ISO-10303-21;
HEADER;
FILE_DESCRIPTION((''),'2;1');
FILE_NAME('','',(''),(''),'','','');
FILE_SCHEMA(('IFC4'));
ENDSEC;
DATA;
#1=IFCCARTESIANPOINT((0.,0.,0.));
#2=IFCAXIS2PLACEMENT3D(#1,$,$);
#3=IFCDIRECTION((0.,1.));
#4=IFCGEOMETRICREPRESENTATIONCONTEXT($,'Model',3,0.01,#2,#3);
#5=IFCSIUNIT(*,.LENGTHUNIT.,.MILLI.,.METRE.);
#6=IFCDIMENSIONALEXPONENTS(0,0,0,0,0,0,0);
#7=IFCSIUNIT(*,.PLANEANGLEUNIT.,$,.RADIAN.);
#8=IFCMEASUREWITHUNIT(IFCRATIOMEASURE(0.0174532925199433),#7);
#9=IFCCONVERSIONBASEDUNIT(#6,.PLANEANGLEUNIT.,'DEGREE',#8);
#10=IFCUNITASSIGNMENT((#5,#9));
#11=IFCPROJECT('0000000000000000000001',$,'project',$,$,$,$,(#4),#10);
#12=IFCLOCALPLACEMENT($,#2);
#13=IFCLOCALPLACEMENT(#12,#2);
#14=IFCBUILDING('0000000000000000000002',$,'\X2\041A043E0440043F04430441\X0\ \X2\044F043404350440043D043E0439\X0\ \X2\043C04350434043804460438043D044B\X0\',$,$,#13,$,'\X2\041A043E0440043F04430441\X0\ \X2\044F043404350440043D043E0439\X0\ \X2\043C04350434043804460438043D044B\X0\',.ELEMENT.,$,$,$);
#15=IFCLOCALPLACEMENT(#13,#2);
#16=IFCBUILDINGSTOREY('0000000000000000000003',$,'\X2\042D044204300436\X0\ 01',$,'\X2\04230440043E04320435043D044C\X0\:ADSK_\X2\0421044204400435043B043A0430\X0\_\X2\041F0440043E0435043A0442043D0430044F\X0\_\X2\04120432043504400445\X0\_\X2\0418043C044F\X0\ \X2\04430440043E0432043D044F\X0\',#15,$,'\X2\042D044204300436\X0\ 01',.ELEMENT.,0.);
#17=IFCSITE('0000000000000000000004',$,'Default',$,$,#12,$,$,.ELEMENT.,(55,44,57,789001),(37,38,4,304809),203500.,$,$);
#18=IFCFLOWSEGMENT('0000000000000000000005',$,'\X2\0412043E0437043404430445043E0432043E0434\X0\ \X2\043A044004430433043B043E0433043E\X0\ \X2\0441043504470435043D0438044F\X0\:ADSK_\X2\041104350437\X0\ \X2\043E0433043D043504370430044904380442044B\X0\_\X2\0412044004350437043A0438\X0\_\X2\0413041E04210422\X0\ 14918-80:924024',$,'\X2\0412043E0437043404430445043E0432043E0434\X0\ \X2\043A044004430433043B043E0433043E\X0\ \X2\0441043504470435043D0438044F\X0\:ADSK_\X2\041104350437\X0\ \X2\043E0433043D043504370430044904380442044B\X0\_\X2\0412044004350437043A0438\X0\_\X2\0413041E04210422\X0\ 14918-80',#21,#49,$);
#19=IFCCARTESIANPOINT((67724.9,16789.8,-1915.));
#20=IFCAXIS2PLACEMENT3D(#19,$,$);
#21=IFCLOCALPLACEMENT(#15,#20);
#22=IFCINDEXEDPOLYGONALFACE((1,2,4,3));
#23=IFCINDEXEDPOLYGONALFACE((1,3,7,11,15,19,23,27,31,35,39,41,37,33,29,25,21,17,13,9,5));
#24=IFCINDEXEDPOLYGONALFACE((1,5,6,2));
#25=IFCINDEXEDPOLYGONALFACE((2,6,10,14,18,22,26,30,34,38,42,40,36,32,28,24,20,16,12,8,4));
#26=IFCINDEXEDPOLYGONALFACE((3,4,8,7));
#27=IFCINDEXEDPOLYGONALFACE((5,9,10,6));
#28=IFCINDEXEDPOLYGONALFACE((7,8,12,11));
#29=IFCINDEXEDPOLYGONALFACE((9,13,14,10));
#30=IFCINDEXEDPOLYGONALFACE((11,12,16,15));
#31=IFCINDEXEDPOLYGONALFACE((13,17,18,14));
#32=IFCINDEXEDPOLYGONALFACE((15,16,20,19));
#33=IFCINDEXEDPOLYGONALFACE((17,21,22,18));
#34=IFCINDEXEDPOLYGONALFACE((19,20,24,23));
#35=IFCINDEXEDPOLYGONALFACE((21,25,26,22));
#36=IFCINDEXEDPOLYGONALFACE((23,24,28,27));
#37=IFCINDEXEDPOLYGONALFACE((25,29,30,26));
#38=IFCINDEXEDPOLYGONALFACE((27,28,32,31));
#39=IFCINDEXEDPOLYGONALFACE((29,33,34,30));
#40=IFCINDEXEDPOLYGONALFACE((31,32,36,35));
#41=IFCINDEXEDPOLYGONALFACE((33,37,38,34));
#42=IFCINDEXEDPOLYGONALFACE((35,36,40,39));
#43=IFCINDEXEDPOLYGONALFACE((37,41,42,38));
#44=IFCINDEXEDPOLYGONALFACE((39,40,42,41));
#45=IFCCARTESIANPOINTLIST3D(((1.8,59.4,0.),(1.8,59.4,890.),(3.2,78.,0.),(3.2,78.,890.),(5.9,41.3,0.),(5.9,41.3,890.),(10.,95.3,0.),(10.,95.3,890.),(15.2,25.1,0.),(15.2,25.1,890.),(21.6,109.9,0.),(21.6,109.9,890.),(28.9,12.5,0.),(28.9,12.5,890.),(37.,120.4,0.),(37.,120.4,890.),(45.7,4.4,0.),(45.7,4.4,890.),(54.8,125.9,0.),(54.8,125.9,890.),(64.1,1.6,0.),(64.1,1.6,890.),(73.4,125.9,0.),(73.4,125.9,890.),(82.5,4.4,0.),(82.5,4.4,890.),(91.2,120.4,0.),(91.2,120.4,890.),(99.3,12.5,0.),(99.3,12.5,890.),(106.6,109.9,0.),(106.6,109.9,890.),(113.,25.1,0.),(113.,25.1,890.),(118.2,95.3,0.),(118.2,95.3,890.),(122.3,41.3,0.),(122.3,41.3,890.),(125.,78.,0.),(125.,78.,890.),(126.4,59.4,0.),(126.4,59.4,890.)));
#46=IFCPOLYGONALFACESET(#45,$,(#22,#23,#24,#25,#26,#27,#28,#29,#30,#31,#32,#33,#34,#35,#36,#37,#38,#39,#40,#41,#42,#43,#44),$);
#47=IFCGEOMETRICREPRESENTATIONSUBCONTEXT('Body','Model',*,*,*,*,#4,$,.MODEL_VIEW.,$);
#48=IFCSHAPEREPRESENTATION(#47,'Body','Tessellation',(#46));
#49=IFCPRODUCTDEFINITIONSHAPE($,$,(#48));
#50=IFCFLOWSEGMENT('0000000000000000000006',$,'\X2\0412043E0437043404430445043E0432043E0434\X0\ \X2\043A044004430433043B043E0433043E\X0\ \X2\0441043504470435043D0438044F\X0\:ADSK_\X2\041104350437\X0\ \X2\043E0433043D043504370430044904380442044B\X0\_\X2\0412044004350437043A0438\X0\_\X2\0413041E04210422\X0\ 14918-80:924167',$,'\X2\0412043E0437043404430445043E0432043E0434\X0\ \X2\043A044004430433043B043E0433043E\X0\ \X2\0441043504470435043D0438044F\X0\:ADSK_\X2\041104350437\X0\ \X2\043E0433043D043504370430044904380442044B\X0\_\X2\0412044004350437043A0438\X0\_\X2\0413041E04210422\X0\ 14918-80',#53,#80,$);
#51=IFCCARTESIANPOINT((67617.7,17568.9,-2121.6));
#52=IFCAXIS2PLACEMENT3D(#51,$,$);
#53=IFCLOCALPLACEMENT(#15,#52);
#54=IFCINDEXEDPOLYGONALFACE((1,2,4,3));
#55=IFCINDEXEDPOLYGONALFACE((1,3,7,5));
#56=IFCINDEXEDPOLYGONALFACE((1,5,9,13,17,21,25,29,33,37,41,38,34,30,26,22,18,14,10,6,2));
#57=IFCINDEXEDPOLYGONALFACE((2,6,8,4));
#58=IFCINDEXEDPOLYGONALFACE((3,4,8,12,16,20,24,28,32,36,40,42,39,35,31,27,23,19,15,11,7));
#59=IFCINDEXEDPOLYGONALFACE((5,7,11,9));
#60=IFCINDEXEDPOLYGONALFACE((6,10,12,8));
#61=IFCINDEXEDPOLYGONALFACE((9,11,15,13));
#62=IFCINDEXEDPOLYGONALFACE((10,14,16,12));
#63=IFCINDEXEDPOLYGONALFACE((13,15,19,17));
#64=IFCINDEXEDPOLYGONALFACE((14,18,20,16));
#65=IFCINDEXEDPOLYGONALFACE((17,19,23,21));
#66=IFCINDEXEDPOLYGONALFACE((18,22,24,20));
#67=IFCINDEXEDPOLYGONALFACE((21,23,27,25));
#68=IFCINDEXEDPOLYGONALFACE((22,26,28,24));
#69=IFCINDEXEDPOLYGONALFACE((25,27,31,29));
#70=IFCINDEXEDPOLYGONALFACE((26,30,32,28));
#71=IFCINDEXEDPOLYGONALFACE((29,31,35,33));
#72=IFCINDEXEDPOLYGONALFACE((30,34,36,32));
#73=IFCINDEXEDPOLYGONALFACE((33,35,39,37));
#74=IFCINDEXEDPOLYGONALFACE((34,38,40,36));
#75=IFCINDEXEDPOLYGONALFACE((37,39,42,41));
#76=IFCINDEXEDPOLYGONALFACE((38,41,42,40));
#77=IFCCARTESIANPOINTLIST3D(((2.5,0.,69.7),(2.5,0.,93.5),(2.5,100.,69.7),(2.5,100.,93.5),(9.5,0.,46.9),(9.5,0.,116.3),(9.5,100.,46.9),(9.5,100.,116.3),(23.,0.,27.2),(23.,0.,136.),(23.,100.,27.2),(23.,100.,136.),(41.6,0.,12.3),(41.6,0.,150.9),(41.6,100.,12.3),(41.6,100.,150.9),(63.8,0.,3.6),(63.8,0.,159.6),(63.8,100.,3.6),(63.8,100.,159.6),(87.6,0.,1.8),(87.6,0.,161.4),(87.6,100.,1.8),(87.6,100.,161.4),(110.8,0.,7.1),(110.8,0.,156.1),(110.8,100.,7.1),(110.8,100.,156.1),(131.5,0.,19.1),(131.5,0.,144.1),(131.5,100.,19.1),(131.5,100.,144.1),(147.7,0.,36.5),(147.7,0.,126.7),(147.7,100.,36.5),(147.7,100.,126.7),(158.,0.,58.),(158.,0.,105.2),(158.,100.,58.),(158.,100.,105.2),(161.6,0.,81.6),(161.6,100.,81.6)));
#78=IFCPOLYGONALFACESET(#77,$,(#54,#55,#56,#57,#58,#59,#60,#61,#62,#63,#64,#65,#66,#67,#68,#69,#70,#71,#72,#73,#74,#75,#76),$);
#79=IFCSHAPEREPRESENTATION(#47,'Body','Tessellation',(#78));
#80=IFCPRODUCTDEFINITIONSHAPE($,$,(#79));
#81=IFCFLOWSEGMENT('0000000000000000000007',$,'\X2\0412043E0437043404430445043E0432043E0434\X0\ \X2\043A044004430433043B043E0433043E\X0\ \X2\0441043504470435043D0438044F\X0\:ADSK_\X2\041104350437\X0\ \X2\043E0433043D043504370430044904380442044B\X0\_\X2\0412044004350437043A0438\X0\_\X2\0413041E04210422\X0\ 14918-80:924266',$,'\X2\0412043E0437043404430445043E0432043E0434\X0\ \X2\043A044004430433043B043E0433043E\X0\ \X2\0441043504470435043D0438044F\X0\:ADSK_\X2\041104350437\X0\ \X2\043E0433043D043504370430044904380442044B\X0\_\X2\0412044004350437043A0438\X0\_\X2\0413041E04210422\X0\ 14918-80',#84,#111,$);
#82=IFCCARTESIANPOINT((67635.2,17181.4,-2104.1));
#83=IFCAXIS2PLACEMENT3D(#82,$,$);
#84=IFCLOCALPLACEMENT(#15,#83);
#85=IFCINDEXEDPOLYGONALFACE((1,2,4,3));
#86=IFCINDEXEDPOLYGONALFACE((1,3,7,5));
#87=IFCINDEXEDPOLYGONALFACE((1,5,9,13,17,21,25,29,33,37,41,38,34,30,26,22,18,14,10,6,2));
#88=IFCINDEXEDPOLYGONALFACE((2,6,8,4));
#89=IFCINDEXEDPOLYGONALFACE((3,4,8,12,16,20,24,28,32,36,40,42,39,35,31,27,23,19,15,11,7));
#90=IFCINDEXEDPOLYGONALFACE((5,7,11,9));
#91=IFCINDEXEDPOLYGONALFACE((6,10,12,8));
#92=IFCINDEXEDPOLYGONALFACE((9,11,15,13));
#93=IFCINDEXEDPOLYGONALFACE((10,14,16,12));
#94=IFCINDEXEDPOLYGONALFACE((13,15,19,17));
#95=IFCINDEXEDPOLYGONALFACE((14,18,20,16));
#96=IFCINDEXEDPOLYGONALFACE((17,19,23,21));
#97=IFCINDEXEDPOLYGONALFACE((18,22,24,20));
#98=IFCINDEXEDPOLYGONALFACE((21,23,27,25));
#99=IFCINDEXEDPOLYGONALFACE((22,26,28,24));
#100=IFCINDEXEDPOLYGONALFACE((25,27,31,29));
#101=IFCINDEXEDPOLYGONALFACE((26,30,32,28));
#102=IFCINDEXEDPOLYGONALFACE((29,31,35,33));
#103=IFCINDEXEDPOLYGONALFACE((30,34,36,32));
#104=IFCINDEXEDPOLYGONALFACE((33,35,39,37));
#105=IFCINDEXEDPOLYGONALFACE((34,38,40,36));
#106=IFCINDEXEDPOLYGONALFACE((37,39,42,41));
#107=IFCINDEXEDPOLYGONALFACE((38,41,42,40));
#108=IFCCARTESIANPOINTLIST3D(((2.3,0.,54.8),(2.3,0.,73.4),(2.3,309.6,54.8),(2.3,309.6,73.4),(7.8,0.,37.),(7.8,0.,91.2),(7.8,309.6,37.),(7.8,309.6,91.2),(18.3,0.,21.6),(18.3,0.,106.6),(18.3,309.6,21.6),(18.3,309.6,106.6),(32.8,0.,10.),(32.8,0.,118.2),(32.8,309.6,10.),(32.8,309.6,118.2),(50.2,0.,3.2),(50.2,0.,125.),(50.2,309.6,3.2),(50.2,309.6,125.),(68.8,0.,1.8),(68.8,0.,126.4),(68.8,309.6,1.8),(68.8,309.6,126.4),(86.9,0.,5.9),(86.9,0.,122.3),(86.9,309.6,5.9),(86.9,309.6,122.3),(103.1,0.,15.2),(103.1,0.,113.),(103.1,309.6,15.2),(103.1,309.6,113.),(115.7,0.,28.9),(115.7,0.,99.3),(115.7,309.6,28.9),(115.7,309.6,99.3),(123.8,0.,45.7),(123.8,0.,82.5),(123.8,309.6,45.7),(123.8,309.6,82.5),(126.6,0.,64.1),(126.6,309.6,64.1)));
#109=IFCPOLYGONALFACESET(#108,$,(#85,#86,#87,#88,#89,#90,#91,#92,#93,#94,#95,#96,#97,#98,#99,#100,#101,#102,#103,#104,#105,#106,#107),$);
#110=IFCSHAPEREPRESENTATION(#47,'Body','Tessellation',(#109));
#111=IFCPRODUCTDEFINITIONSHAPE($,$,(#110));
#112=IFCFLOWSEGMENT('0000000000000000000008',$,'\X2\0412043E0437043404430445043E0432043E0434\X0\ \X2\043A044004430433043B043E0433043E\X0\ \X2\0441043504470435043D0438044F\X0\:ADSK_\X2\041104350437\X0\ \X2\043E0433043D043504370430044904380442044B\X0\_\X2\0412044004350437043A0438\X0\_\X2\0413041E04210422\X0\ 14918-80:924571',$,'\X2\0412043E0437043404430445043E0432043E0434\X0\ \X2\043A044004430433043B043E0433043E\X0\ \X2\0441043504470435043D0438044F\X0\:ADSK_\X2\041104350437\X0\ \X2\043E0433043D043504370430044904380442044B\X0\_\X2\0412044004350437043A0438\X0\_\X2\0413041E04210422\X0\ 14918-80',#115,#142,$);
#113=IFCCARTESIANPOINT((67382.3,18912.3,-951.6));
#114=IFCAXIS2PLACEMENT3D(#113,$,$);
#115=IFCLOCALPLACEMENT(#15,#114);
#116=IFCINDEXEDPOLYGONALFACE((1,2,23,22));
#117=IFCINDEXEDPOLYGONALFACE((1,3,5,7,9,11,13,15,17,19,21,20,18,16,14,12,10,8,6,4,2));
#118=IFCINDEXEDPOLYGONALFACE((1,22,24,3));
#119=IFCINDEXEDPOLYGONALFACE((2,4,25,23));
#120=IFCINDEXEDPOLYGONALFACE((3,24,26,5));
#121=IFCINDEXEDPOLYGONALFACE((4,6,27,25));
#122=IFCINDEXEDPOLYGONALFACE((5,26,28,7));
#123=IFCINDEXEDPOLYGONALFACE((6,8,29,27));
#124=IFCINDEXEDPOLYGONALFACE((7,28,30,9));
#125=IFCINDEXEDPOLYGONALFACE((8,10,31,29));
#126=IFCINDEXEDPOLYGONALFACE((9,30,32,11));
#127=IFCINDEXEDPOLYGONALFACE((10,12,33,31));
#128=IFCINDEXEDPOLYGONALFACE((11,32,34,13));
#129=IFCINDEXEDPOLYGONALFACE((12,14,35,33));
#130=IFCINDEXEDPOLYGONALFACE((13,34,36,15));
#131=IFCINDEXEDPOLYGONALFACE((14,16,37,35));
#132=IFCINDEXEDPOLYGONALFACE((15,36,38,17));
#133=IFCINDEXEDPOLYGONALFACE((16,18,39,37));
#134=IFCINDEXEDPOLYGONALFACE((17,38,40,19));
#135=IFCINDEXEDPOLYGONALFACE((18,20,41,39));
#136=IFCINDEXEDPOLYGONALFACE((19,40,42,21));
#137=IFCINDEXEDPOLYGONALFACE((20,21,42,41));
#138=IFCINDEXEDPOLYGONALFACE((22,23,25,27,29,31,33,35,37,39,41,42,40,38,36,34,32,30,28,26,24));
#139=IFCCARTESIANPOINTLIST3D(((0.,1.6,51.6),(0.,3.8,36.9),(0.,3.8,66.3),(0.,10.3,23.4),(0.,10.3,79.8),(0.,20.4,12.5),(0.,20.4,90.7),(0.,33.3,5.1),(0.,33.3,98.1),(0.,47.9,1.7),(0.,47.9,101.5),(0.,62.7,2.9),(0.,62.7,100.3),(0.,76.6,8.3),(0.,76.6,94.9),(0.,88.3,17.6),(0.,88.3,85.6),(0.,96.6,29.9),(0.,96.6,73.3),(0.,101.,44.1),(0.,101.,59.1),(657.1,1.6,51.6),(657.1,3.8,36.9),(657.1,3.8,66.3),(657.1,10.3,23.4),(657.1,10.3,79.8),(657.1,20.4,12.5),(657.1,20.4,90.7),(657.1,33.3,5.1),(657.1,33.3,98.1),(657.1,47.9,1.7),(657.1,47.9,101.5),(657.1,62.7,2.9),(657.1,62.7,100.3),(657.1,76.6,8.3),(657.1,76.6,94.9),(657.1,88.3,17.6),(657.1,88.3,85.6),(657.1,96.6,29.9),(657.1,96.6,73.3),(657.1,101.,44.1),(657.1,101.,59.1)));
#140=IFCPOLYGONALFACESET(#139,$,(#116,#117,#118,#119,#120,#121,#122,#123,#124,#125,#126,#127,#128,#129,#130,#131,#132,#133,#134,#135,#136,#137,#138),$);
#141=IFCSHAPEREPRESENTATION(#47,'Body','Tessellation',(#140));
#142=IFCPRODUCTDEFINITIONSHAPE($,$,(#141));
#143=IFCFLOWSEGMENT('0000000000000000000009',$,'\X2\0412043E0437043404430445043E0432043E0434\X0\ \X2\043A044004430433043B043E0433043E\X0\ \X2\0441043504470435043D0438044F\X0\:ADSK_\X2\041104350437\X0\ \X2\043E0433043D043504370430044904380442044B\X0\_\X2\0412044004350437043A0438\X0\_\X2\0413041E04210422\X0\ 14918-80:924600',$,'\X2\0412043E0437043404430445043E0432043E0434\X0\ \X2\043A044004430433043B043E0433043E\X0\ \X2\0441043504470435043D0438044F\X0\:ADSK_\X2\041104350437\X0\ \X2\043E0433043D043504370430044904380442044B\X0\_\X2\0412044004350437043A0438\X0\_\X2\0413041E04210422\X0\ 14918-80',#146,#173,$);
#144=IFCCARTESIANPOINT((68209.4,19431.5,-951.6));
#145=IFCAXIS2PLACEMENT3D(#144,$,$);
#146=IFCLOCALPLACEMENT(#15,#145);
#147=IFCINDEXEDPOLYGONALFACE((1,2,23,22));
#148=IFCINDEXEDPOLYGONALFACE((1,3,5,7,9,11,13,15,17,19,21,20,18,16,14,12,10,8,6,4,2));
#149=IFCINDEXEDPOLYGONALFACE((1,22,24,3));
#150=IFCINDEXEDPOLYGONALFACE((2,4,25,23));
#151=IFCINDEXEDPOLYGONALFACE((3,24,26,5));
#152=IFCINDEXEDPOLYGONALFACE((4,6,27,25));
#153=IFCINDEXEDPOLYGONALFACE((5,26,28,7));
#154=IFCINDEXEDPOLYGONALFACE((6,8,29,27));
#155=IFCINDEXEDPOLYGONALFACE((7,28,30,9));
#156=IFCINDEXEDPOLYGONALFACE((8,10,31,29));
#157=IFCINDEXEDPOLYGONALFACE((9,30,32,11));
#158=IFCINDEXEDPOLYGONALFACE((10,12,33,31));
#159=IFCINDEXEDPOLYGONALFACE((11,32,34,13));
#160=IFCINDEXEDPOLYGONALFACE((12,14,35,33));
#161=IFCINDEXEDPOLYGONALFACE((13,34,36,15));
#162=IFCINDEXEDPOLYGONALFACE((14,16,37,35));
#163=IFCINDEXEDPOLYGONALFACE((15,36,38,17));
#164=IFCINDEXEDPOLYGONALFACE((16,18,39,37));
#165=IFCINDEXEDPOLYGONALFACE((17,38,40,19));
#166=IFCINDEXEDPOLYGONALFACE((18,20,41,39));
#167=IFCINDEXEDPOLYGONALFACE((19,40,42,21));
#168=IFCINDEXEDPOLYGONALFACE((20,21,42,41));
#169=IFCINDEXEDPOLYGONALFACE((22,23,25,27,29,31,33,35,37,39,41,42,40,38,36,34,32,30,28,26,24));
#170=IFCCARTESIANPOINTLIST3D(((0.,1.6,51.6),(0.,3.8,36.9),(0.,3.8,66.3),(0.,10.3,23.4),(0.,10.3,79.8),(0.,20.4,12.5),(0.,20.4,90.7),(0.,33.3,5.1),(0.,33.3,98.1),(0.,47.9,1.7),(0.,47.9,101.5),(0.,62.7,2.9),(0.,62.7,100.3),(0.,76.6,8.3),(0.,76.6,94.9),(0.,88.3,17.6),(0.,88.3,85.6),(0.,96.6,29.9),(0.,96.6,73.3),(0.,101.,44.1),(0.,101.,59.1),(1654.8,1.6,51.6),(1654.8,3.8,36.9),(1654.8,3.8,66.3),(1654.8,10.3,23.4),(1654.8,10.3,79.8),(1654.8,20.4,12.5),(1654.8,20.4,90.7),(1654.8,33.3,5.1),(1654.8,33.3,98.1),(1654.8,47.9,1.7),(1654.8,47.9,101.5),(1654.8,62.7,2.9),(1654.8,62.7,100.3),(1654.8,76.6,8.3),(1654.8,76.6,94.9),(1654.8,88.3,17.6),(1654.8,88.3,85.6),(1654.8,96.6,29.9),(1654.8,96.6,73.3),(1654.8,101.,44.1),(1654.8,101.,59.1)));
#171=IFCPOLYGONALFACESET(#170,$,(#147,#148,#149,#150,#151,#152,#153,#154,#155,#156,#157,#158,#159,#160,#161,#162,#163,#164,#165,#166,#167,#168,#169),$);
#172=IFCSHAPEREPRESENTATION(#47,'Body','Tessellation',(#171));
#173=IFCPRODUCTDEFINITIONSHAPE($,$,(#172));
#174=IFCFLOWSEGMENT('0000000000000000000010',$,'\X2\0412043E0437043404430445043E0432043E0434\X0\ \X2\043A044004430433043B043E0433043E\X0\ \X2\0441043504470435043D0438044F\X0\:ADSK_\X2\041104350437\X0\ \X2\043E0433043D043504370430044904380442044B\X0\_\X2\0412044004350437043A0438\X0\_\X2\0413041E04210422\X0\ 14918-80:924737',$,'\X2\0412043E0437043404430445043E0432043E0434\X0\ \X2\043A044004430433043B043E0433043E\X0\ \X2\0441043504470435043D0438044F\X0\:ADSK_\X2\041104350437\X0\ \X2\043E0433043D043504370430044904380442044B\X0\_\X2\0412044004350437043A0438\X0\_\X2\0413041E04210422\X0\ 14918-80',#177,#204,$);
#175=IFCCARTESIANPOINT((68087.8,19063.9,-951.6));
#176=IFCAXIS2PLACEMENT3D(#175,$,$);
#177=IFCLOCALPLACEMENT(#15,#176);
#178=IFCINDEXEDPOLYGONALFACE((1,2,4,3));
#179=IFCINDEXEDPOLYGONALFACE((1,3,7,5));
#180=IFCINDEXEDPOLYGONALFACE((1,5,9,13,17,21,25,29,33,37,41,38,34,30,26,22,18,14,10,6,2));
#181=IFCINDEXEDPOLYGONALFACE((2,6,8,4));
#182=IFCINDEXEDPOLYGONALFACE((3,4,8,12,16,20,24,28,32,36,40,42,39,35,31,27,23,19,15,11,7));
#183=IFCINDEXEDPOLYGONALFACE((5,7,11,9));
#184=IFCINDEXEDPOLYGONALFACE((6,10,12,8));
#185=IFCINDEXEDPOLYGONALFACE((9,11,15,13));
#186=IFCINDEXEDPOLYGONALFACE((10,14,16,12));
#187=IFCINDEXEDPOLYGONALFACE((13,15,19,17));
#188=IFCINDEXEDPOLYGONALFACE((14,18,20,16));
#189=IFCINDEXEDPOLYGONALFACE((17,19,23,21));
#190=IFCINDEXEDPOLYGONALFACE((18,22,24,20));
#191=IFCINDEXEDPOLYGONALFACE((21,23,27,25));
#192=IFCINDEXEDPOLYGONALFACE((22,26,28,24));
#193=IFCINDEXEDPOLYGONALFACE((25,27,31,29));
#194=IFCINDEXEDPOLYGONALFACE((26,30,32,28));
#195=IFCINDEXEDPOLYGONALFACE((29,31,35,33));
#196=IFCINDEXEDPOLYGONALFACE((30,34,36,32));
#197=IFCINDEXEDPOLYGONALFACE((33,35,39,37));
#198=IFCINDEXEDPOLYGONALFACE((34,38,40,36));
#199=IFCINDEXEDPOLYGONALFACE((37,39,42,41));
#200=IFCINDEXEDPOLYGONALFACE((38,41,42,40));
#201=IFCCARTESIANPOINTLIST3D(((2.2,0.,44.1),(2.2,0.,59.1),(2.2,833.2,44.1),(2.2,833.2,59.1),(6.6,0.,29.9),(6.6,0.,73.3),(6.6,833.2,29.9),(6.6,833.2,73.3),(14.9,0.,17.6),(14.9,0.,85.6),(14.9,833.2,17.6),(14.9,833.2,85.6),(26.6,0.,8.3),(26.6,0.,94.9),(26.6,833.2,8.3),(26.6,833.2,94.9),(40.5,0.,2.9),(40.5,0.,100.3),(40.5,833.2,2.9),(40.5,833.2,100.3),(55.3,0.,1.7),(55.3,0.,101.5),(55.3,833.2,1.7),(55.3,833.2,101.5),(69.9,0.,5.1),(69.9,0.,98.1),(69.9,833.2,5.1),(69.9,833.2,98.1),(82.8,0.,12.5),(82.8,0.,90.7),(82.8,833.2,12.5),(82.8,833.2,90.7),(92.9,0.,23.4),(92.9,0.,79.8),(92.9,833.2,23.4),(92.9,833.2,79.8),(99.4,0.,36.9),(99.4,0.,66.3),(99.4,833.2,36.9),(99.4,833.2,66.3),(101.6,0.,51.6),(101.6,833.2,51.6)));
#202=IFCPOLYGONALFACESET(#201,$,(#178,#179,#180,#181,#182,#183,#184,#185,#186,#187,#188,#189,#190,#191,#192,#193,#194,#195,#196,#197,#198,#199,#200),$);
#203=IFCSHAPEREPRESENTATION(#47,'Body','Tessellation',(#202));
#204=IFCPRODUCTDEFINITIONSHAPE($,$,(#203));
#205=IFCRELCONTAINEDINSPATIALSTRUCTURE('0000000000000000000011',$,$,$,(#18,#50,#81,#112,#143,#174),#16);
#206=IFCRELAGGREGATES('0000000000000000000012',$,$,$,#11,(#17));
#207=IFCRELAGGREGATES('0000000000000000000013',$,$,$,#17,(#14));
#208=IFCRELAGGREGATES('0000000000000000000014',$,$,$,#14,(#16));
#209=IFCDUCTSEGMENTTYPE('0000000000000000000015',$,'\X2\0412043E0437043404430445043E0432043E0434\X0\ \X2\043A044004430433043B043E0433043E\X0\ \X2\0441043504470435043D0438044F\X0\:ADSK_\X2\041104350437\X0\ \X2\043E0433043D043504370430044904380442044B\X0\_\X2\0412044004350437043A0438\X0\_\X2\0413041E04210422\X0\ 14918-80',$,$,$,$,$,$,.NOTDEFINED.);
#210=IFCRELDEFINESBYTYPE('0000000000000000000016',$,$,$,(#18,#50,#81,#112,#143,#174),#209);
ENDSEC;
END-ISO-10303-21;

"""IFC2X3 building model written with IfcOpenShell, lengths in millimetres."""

from ifc_helpers import new_model, entity, si_unit, converted_unit, direction, frame, origin, origin_2d_with_axis, place, context, subcontext, project, spatial, circle, extrude, type_object, element, save


model = new_model("IFC2X3")

# Units and contexts
model_context = context("Model", 3, precision=0.01, world=origin(), true_north=direction((0.0, 1.0)))
body_context = subcontext(model_context, "Body", "Model", "MODEL_VIEW")
ifc_project = project(units=[si_unit("LENGTHUNIT", "METRE", prefix="MILLI"), converted_unit("PLANEANGLEUNIT", "DEGREE", entity("IfcRatioMeasure", 0.0174532925199433), si_unit("PLANEANGLEUNIT", "RADIAN"), dimensions=[0, 0, 0, 0, 0, 0, 0])], contexts=[model_context])

# Site, building, storey
site_placement = place(None, origin())
site = spatial("IfcSite", under=ifc_project, at=site_placement, Name="Default", CompositionType="ELEMENT", RefLatitude=(55, 44, 57, 789001), RefLongitude=(37, 38, 4, 304809), RefElevation=203500.0)
building_placement = place(site_placement, origin())
building = spatial("IfcBuilding", under=site, at=building_placement, Name="Корпус ядерной медицины", LongName="Корпус ядерной медицины", CompositionType="ELEMENT")
storey_placement = place(building_placement, origin())
storey = spatial("IfcBuildingStorey", under=building, at=storey_placement, Name="Этаж 01", ObjectType="Уровень:ADSK_Стрелка_Проектная_Вверх_Имя уровня", LongName="Этаж 01", CompositionType="ELEMENT", Elevation=0.0)

# Flow segments
duct_segment_type = type_object("IfcDuctSegmentType", Name="Воздуховод круглого сечения:ADSK_Без огнезащиты_Врезки_ГОСТ 14918-80", PredefinedType="NOTDEFINED")
flow_segment_1_placement = place(storey_placement, frame((67724.9, 16789.8, -1915.0)))
element("IfcFlowSegment", 1, at=flow_segment_1_placement, inside=storey, type_object=duct_segment_type, Name="Воздуховод круглого сечения:ADSK_Без огнезащиты_Врезки_ГОСТ 14918-80:924024", ObjectType="Воздуховод круглого сечения:ADSK_Без огнезащиты_Врезки_ГОСТ 14918-80", context=body_context, shape_type="SweptSolid", body=[
    extrude(circle(Radius=62.5, at=origin_2d_with_axis()), frame((64.1, 64.1, 0.0), z_axis=(0.0, 0.0, 1.0), x_axis=(0.0, -1.0, 0.0)), (0.0, 0.0, 1.0), 890.0),
])
flow_segment_2_placement = place(storey_placement, frame((67617.7, 17568.9, -2121.6)))
element("IfcFlowSegment", 2, at=flow_segment_2_placement, inside=storey, type_object=duct_segment_type, Name="Воздуховод круглого сечения:ADSK_Без огнезащиты_Врезки_ГОСТ 14918-80:924167", ObjectType="Воздуховод круглого сечения:ADSK_Без огнезащиты_Врезки_ГОСТ 14918-80", context=body_context, shape_type="SweptSolid", body=[
    extrude(circle(Radius=80.0, at=origin_2d_with_axis()), frame((81.6, 0.0, 81.6), z_axis=(0.0, 1.0, 0.0), x_axis=(1.0, 0.0, 0.0)), (0.0, 0.0, 1.0), 100.0),
])
flow_segment_3_placement = place(storey_placement, frame((67635.2, 17181.4, -2104.1)))
element("IfcFlowSegment", 3, at=flow_segment_3_placement, inside=storey, type_object=duct_segment_type, Name="Воздуховод круглого сечения:ADSK_Без огнезащиты_Врезки_ГОСТ 14918-80:924266", ObjectType="Воздуховод круглого сечения:ADSK_Без огнезащиты_Врезки_ГОСТ 14918-80", context=body_context, shape_type="SweptSolid", body=[
    extrude(circle(Radius=62.5, at=origin_2d_with_axis()), frame((64.1, 0.0, 64.1), z_axis=(0.0, 1.0, 0.0), x_axis=(1.0, 0.0, 0.0)), (0.0, 0.0, 1.0), 309.6),
])
flow_segment_4_placement = place(storey_placement, frame((67382.3, 18912.3, -951.6)))
element("IfcFlowSegment", 4, at=flow_segment_4_placement, inside=storey, type_object=duct_segment_type, Name="Воздуховод круглого сечения:ADSK_Без огнезащиты_Врезки_ГОСТ 14918-80:924571", ObjectType="Воздуховод круглого сечения:ADSK_Без огнезащиты_Врезки_ГОСТ 14918-80", context=body_context, shape_type="SweptSolid", body=[
    extrude(circle(Radius=50.0, at=origin_2d_with_axis()), frame((0.0, 51.6, 51.6), z_axis=(1.0, 0.0, 0.0), x_axis=(0.0, -1.0, 0.0)), (0.0, 0.0, 1.0), 657.1),
])
flow_segment_5_placement = place(storey_placement, frame((68209.4, 19431.5, -951.6)))
element("IfcFlowSegment", 5, at=flow_segment_5_placement, inside=storey, type_object=duct_segment_type, Name="Воздуховод круглого сечения:ADSK_Без огнезащиты_Врезки_ГОСТ 14918-80:924600", ObjectType="Воздуховод круглого сечения:ADSK_Без огнезащиты_Врезки_ГОСТ 14918-80", context=body_context, shape_type="SweptSolid", body=[
    extrude(circle(Radius=50.0, at=origin_2d_with_axis()), frame((0.0, 51.6, 51.6), z_axis=(1.0, 0.0, 0.0), x_axis=(0.0, -1.0, 0.0)), (0.0, 0.0, 1.0), 1654.8),
])
flow_segment_6_placement = place(storey_placement, frame((68087.8, 19063.9, -951.6)))
element("IfcFlowSegment", 6, at=flow_segment_6_placement, inside=storey, type_object=duct_segment_type, Name="Воздуховод круглого сечения:ADSK_Без огнезащиты_Врезки_ГОСТ 14918-80:924737", ObjectType="Воздуховод круглого сечения:ADSK_Без огнезащиты_Врезки_ГОСТ 14918-80", context=body_context, shape_type="SweptSolid", body=[
    extrude(circle(Radius=50.0, at=origin_2d_with_axis()), frame((51.6, 0.0, 51.6), z_axis=(0.0, 1.0, 0.0), x_axis=(1.0, 0.0, 0.0)), (0.0, 0.0, 1.0), 833.2),
])

save(model, "model.ifc")
